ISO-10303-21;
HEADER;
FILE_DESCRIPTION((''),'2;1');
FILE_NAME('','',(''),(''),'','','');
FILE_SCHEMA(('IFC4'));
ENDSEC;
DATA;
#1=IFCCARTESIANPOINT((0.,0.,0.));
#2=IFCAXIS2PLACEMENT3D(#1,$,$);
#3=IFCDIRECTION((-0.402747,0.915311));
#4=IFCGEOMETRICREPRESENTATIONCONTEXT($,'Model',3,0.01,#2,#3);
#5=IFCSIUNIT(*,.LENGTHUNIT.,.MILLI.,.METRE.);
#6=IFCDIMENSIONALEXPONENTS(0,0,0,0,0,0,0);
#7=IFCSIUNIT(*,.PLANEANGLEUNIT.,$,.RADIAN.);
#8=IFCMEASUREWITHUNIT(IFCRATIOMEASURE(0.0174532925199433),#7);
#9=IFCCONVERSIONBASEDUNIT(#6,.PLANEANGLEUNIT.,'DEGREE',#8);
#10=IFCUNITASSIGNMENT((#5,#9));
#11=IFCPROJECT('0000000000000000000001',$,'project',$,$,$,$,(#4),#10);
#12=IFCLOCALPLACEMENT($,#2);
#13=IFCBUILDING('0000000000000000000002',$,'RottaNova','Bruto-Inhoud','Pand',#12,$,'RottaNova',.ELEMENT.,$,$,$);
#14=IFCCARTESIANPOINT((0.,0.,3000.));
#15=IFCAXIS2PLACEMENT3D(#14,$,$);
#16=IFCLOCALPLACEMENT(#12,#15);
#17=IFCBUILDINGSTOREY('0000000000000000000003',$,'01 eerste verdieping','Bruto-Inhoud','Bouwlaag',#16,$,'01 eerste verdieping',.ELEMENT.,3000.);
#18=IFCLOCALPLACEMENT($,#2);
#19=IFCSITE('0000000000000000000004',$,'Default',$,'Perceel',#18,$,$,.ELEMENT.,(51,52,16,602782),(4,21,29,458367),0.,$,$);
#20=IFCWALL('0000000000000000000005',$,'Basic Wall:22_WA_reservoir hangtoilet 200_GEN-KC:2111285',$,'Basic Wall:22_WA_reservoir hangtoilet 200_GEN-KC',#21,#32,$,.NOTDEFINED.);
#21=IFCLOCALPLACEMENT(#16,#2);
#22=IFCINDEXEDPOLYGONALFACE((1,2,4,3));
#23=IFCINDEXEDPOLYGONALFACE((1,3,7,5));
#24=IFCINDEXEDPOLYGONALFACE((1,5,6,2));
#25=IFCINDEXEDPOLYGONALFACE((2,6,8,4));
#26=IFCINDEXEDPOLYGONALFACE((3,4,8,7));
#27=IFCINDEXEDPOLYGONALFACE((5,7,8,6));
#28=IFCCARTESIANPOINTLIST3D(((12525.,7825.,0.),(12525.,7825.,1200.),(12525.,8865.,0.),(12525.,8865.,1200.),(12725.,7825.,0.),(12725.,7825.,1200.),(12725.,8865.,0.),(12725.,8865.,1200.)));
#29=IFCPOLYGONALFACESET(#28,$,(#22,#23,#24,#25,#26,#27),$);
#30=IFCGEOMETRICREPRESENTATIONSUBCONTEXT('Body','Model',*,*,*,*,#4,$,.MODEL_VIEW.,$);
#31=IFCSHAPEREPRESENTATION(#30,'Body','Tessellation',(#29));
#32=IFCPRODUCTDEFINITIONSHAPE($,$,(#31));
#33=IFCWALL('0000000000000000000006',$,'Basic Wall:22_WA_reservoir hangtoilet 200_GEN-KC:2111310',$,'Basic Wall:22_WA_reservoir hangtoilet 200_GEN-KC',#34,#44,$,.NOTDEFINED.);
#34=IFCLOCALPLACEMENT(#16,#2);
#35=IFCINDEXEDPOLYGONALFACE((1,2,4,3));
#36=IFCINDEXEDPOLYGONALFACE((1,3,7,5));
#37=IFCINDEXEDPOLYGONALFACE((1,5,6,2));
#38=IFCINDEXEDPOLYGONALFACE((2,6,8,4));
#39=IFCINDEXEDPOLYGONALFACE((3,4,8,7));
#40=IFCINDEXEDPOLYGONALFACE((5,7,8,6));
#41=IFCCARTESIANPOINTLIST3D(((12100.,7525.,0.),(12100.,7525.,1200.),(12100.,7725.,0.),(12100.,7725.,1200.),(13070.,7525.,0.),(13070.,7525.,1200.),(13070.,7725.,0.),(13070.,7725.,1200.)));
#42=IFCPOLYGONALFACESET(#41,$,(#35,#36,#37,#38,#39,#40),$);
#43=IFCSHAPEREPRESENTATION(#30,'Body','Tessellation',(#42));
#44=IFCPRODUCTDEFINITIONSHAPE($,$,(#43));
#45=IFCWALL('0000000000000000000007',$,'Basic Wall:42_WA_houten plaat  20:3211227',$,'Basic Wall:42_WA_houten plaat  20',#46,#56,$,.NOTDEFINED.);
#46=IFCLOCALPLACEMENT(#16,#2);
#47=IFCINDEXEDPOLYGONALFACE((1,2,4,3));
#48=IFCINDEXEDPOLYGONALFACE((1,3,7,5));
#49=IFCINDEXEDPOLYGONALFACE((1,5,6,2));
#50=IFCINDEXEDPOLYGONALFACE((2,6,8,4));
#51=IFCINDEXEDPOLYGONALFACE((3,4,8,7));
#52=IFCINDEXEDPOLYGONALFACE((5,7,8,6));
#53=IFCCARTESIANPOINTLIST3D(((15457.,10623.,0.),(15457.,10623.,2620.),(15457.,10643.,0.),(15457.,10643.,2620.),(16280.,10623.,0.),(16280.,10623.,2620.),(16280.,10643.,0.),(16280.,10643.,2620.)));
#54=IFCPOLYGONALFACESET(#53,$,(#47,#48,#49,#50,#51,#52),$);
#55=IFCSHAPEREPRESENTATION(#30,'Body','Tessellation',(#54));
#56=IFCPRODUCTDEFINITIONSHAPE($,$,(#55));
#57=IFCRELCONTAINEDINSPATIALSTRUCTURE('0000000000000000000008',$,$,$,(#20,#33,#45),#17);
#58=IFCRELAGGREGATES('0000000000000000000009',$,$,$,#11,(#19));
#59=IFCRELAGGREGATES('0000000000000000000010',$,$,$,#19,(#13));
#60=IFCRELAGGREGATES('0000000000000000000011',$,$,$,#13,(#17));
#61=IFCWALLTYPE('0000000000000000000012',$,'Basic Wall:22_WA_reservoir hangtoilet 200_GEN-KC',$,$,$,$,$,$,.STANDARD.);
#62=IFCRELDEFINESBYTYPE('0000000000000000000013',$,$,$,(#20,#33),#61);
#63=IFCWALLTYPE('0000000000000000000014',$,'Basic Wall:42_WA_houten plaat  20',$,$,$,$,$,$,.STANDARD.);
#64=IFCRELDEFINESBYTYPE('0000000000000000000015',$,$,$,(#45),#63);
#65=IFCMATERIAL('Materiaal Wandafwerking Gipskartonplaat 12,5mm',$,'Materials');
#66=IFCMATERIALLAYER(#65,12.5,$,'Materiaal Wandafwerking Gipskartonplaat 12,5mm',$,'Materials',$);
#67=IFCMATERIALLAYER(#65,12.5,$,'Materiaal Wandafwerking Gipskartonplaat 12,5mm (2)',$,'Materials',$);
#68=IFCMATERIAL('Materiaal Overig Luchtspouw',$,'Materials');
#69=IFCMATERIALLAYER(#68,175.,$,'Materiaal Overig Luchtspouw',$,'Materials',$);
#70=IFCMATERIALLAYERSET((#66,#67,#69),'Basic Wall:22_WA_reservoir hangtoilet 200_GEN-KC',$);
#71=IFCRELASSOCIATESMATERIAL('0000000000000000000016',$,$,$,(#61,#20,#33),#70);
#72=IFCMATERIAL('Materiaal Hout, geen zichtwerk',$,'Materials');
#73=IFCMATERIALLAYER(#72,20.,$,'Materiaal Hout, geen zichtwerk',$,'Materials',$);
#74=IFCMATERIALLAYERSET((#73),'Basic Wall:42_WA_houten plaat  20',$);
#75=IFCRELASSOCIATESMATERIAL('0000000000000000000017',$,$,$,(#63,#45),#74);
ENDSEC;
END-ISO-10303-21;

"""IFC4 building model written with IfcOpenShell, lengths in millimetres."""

from ifc_helpers import new_model, entity, si_unit, converted_unit, direction, frame, frame_2d, origin, place, context, subcontext, project, spatial, rectangle, extrude, material, layer, layer_set, type_object, element, save


model = new_model("IFC4")

# Units and contexts
model_context = context("Model", 3, precision=0.01, world=origin(), true_north=direction((-0.402747, 0.915311)))
body_context = subcontext(model_context, "Body", "Model", "MODEL_VIEW")
ifc_project = project(units=[si_unit("LENGTHUNIT", "METRE", prefix="MILLI"), converted_unit("PLANEANGLEUNIT", "DEGREE", entity("IfcRatioMeasure", 0.0174532925199433), si_unit("PLANEANGLEUNIT", "RADIAN"), dimensions=[0, 0, 0, 0, 0, 0, 0])], contexts=[model_context])

# Site, building, storey
site_placement = place(None, origin())
site = spatial("IfcSite", under=ifc_project, at=site_placement, Name="Default", ObjectType="Perceel", CompositionType="ELEMENT", RefLatitude=(51, 52, 16, 602782), RefLongitude=(4, 21, 29, 458367), RefElevation=0.0)
building_placement = place(None, origin())
building = spatial("IfcBuilding", under=site, at=building_placement, Name="RottaNova", Description="Bruto-Inhoud", ObjectType="Pand", LongName="RottaNova", CompositionType="ELEMENT")
storey_placement = place(building_placement, frame((0.0, 0.0, 3000.0)))
storey = spatial("IfcBuildingStorey", under=building, at=storey_placement, Name="01 eerste verdieping", Description="Bruto-Inhoud", ObjectType="Bouwlaag", LongName="01 eerste verdieping", CompositionType="ELEMENT", Elevation=3000.0)

# Walls
ifc_material_1 = material(Name="Materiaal Wandafwerking Gipskartonplaat 12,5mm", Category="Materials")
ifc_layer_1 = layer(ifc_material_1, 12.5, Name="Materiaal Wandafwerking Gipskartonplaat 12,5mm", Category="Materials")
ifc_layer_2 = layer(ifc_material_1, 12.5, Name="Materiaal Wandafwerking Gipskartonplaat 12,5mm (2)", Category="Materials")
ifc_material_2 = material(Name="Materiaal Overig Luchtspouw", Category="Materials")
ifc_layer_3 = layer(ifc_material_2, 175.0, Name="Materiaal Overig Luchtspouw", Category="Materials")
ifc_layer_set_1 = layer_set([ifc_layer_1, ifc_layer_2, ifc_layer_3], Name="Basic Wall:22_WA_reservoir hangtoilet 200_GEN-KC")
wall_type_1 = type_object("IfcWallType", Name="Basic Wall:22_WA_reservoir hangtoilet 200_GEN-KC", PredefinedType="STANDARD", material=ifc_layer_set_1)
wall_1_placement = place(storey_placement, frame((12625.0, 8865.0, 0.0), z_axis=(0.0, 0.0, 1.0), x_axis=(0.0, -1.0, 0.0)))
element("IfcWall", 1, at=wall_1_placement, inside=storey, type_object=wall_type_1, material=ifc_layer_set_1, Name="Basic Wall:22_WA_reservoir hangtoilet 200_GEN-KC:2111285", ObjectType="Basic Wall:22_WA_reservoir hangtoilet 200_GEN-KC", PredefinedType="NOTDEFINED", context=body_context, shape_type="SweptSolid", body=[
    extrude(rectangle(XDim=1040.0, YDim=200.0, at=frame_2d((520.0, 0.0), x_axis=(-1.0, 0.0))), origin(), (0.0, 0.0, 1.0), 1200.0),
])
wall_2_placement = place(storey_placement, frame((13070.0, 7625.0, 0.0), z_axis=(0.0, 0.0, 1.0), x_axis=(-1.0, 0.0, 0.0)))
element("IfcWall", 2, at=wall_2_placement, inside=storey, type_object=wall_type_1, material=ifc_layer_set_1, Name="Basic Wall:22_WA_reservoir hangtoilet 200_GEN-KC:2111310", ObjectType="Basic Wall:22_WA_reservoir hangtoilet 200_GEN-KC", PredefinedType="NOTDEFINED", context=body_context, shape_type="SweptSolid", body=[
    extrude(rectangle(XDim=970.0, YDim=200.0, at=frame_2d((485.0, 0.0), x_axis=(-1.0, 0.0))), origin(), (0.0, 0.0, 1.0), 1200.0),
])
ifc_material_3 = material(Name="Materiaal Hout, geen zichtwerk", Category="Materials")
ifc_layer_4 = layer(ifc_material_3, 20.0, Name="Materiaal Hout, geen zichtwerk", Category="Materials")
ifc_layer_set_2 = layer_set([ifc_layer_4], Name="Basic Wall:42_WA_houten plaat  20")
wall_type_2 = type_object("IfcWallType", Name="Basic Wall:42_WA_houten plaat  20", PredefinedType="STANDARD", material=ifc_layer_set_2)
wall_3_placement = place(storey_placement, frame((16280.0, 10633.0, 0.0), z_axis=(0.0, 0.0, 1.0), x_axis=(-1.0, 0.0, 0.0)))
element("IfcWall", 3, at=wall_3_placement, inside=storey, type_object=wall_type_2, material=ifc_layer_set_2, Name="Basic Wall:42_WA_houten plaat  20:3211227", ObjectType="Basic Wall:42_WA_houten plaat  20", PredefinedType="NOTDEFINED", context=body_context, shape_type="SweptSolid", body=[
    extrude(rectangle(XDim=823.0, YDim=20.0, at=frame_2d((411.5, 0.0), x_axis=(-1.0, 0.0))), origin(), (0.0, 0.0, 1.0), 2620.0),
])

save(model, "model.ifc")
